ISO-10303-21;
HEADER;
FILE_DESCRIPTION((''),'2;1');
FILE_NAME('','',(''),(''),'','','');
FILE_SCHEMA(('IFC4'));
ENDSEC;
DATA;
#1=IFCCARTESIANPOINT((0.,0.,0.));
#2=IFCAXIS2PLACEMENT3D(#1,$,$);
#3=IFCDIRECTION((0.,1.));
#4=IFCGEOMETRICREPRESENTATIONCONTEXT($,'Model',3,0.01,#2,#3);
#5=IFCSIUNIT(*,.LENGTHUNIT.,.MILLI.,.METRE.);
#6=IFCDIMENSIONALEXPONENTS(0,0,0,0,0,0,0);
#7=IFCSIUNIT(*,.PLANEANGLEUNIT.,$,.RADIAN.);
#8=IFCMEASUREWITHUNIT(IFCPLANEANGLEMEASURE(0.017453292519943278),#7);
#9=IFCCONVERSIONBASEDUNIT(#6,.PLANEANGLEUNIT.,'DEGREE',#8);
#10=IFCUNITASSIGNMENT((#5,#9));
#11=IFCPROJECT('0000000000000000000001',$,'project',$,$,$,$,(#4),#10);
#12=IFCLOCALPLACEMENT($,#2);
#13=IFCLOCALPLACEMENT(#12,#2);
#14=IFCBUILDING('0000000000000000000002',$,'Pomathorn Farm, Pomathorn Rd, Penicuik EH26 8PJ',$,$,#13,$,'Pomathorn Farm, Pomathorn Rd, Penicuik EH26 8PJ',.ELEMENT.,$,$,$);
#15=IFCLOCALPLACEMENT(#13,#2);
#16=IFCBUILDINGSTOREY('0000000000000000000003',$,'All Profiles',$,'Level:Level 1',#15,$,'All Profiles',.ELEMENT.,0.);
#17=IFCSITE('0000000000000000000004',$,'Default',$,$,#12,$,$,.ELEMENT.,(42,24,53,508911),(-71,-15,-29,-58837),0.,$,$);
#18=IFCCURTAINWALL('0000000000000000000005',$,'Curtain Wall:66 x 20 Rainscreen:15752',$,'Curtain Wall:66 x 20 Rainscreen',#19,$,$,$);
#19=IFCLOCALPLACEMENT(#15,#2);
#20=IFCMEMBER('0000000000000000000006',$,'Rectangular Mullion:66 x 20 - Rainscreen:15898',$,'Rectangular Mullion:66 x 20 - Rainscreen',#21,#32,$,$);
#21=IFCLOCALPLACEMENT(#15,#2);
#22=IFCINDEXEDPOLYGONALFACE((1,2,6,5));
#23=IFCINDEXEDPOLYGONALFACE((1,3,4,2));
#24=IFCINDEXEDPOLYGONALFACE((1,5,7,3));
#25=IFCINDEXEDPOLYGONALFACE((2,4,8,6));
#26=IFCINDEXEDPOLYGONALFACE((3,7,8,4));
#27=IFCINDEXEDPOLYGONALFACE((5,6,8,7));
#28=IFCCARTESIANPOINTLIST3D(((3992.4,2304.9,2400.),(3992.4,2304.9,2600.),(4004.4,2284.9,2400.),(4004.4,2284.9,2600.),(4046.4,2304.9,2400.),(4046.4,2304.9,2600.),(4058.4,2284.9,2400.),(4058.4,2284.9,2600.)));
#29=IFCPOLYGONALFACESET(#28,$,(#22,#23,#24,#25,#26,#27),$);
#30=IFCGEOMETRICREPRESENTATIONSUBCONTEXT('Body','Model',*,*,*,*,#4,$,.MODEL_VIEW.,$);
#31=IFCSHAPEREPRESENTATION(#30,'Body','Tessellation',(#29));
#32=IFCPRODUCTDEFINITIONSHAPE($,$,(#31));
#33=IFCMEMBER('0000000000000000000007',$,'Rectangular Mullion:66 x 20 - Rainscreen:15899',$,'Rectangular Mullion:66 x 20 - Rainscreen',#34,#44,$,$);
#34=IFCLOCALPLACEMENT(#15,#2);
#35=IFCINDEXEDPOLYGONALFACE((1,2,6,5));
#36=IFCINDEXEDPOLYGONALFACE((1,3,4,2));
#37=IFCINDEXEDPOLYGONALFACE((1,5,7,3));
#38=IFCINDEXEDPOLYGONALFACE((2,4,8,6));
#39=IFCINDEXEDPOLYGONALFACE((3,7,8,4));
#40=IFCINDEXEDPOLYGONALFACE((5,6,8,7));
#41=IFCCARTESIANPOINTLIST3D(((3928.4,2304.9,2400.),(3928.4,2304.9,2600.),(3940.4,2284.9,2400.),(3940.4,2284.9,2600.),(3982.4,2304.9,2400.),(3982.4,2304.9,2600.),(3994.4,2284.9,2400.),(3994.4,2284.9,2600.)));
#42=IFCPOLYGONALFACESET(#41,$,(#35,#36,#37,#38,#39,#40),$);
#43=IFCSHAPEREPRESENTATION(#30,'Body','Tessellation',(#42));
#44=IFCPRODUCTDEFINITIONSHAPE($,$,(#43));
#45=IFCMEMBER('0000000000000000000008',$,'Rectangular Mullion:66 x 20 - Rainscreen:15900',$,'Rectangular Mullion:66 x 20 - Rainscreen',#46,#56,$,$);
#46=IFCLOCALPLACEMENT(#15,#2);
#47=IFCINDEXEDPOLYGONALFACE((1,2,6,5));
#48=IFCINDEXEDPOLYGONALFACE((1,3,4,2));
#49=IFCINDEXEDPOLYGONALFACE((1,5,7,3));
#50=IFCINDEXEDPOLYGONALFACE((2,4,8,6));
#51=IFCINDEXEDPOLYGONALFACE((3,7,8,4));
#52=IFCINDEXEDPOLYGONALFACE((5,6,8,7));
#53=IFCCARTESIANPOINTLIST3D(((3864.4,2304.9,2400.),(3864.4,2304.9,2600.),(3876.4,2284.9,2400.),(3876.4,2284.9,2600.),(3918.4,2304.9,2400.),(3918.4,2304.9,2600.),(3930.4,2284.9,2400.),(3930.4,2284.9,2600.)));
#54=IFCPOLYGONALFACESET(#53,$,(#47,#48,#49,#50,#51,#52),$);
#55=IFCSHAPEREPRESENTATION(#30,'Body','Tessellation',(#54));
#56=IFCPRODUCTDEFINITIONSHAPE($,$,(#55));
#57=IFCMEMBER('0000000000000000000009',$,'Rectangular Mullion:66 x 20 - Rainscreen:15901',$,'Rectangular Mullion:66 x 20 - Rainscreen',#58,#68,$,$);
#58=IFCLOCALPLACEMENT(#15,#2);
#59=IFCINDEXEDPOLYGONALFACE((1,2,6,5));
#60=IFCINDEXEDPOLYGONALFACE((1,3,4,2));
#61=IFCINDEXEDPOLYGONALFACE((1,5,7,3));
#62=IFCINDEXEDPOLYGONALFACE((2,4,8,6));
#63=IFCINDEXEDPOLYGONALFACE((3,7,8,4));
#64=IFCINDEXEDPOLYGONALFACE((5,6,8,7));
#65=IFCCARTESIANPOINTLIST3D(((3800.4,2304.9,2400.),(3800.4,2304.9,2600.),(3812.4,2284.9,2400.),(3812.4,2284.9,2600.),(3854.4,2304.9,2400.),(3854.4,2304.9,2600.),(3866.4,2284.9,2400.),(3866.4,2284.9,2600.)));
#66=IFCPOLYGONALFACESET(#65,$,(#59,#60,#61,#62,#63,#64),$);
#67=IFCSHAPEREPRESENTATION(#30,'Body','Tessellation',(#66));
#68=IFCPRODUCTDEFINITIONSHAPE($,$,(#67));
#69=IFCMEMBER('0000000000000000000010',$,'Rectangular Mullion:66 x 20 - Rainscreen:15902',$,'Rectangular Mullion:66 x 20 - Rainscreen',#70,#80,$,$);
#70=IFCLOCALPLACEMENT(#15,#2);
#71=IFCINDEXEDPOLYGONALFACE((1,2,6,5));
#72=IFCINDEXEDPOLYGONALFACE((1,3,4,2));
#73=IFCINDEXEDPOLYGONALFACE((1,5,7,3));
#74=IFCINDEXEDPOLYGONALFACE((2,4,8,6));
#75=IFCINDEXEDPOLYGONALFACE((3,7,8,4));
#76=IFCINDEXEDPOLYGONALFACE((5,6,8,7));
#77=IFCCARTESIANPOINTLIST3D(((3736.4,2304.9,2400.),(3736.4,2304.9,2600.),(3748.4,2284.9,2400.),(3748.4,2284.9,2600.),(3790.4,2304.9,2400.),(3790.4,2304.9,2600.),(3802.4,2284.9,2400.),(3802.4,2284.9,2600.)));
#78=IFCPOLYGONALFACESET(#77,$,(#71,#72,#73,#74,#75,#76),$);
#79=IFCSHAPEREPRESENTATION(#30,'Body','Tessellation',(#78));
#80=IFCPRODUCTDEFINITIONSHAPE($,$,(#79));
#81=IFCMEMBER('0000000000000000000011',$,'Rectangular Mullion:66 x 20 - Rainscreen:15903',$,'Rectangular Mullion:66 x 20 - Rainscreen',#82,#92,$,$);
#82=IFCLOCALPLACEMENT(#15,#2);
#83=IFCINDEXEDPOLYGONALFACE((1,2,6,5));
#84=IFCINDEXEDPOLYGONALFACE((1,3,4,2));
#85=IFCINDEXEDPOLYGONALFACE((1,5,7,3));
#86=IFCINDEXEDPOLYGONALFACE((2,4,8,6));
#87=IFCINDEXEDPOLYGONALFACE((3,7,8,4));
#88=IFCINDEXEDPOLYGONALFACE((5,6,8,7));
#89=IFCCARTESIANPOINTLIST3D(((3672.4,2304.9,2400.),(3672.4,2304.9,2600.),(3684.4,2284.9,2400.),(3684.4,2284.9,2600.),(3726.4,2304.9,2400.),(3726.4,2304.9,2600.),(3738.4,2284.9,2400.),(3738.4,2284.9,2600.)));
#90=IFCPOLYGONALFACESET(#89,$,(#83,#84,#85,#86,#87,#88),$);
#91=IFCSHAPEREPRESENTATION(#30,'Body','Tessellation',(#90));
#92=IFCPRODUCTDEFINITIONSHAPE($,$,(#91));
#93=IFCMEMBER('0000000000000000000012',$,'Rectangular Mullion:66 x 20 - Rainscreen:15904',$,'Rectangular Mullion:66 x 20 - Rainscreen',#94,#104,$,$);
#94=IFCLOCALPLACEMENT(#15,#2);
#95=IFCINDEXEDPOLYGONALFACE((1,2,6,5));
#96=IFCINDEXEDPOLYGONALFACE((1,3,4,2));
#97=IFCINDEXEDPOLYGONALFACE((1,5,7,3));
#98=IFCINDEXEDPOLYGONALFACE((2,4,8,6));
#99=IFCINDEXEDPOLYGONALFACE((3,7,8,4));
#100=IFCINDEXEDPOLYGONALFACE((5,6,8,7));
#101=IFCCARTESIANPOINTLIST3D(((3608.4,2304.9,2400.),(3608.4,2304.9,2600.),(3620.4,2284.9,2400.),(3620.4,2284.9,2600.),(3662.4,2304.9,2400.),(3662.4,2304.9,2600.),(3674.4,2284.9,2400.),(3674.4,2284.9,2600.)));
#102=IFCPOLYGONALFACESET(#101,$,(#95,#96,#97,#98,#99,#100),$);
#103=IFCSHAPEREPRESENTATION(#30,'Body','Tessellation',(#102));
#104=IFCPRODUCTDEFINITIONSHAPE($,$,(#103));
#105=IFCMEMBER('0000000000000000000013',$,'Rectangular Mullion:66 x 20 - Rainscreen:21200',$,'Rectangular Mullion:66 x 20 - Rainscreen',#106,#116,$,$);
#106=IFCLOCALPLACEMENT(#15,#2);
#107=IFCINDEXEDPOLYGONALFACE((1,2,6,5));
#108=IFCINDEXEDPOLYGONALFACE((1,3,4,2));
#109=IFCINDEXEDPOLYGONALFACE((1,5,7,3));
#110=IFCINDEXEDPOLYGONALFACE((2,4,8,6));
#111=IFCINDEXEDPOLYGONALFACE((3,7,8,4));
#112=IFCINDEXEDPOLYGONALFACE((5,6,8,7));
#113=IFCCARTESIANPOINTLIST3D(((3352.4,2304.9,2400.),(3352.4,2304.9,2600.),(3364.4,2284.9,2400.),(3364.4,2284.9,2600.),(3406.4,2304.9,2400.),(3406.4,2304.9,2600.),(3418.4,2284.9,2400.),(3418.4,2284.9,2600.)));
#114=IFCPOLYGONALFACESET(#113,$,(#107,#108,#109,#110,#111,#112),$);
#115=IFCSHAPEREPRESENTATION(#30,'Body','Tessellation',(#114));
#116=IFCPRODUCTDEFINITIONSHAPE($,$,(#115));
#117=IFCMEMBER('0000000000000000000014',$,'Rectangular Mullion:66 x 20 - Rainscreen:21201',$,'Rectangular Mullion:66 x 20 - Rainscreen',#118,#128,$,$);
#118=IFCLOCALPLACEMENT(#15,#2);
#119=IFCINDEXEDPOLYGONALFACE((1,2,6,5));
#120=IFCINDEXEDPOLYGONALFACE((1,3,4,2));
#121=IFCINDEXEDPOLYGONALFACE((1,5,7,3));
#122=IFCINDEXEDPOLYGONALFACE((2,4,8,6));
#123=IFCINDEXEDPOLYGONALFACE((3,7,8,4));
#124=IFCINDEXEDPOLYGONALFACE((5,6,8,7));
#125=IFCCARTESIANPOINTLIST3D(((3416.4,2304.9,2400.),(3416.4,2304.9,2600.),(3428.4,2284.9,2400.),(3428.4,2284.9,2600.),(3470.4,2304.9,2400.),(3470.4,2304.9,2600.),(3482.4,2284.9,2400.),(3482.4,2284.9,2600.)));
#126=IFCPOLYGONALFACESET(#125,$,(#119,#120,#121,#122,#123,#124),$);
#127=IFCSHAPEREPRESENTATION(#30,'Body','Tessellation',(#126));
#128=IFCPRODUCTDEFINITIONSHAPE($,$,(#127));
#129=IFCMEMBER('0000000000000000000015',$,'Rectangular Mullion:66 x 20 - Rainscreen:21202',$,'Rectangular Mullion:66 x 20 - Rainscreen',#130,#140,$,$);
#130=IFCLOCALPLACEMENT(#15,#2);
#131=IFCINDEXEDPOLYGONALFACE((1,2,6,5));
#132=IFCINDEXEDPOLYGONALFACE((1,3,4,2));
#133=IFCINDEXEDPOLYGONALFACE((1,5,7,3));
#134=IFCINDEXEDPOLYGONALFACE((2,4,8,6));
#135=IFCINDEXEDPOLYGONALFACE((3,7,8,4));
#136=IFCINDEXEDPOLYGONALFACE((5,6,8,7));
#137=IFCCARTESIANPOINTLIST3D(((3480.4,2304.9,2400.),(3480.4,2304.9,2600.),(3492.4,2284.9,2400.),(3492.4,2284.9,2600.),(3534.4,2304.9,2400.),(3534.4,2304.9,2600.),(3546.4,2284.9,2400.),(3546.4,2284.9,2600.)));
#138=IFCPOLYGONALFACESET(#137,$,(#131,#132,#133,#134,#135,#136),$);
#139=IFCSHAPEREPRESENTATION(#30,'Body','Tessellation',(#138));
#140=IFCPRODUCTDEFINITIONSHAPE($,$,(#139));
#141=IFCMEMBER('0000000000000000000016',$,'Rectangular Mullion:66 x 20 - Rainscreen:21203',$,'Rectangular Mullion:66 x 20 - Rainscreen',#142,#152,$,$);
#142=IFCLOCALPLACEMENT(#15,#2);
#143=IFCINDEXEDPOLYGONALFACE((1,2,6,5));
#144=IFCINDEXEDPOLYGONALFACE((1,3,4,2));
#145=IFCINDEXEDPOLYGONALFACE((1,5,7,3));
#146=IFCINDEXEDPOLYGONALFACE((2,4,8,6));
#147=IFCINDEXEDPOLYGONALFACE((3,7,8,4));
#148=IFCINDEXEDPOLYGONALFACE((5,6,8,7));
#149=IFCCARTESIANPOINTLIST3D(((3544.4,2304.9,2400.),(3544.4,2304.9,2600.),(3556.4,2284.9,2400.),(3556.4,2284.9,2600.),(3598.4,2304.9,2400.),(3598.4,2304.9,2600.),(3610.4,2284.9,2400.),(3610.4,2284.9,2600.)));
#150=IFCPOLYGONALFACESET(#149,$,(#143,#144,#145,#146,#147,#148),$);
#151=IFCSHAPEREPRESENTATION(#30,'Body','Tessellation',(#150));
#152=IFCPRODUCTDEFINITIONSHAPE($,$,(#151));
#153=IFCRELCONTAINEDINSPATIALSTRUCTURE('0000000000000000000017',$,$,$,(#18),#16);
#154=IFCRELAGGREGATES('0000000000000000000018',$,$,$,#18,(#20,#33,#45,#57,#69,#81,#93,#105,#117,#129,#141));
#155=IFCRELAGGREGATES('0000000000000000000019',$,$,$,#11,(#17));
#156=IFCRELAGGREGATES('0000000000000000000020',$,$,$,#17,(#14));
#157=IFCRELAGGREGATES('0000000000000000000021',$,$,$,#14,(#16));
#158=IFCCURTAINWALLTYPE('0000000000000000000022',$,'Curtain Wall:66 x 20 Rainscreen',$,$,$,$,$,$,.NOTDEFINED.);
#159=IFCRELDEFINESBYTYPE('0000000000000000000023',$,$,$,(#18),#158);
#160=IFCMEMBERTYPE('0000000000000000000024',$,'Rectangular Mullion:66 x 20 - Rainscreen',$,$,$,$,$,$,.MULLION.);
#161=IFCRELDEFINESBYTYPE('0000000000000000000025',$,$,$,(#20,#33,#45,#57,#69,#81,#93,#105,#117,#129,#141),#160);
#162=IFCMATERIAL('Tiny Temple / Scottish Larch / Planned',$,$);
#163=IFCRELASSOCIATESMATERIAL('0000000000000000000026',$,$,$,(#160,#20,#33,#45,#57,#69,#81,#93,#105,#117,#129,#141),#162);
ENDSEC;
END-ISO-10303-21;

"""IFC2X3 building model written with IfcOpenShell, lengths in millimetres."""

from ifc_helpers import new_model, entity, si_unit, converted_unit, direction, frame, origin, place, context, subcontext, project, spatial, polyline, outline, extrude, source, transform, mapped, material, type_object, type_shapes, element, aggregate, save


model = new_model("IFC2X3")

# Units and contexts
model_context = context("Model", 3, precision=0.01, world=origin(), true_north=direction((0.0, 1.0)))
body_context = subcontext(model_context, "Body", "Model", "MODEL_VIEW")
ifc_project = project(units=[si_unit("LENGTHUNIT", "METRE", prefix="MILLI"), converted_unit("PLANEANGLEUNIT", "DEGREE", entity("IfcPlaneAngleMeasure", 0.017453292519943278), si_unit("PLANEANGLEUNIT", "RADIAN"), dimensions=[0, 0, 0, 0, 0, 0, 0])], contexts=[model_context])

# Site, building, storey
site_placement = place(None, origin())
site = spatial("IfcSite", under=ifc_project, at=site_placement, Name="Default", CompositionType="ELEMENT", RefLatitude=(42, 24, 53, 508911), RefLongitude=(-71, -15, -29, -58837), RefElevation=0.0)
building_placement = place(site_placement, origin())
building = spatial("IfcBuilding", under=site, at=building_placement, Name="Pomathorn Farm, Pomathorn Rd, Penicuik EH26 8PJ", LongName="Pomathorn Farm, Pomathorn Rd, Penicuik EH26 8PJ", CompositionType="ELEMENT")
storey_placement = place(building_placement, origin())
storey = spatial("IfcBuildingStorey", under=building, at=storey_placement, Name="All Profiles", ObjectType="Level:Level 1", LongName="All Profiles", CompositionType="ELEMENT", Elevation=0.0)

# Curtain wall, members
ifc_material = material(Name="Tiny Temple / Scottish Larch / Planned")
curtain_wall_type_1 = type_object("IfcCurtainWallType", Name="Curtain Wall:66 x 20 Rainscreen", PredefinedType="NOTDEFINED")
curtain_wall_1_placement = place(storey_placement, origin())
curtain_wall_1 = element("IfcCurtainWall", 1, at=curtain_wall_1_placement, inside=storey, type_object=curtain_wall_type_1, Name="Curtain Wall:66 x 20 Rainscreen:15752", ObjectType="Curtain Wall:66 x 20 Rainscreen")
member_type_1 = type_object("IfcMemberType", Name="Rectangular Mullion:66 x 20 - Rainscreen", PredefinedType="MULLION", material=ifc_material)
shared_shape_1 = source(origin(), body_context, "Body", "SweptSolid", [
    extrude(outline(polyline([(2.2, -23.2), (25.6, -23.2), (-2.2, 23.2), (-25.6, 23.2), (2.2, -23.2)])), frame((-33.0, -10.0, -200.0), z_axis=(0.0, 0.0, 1.0), x_axis=(0.514496, 0.857493, 0.0)), (0.0, 0.0, 1.0), 200.0),
])
type_shapes(member_type_1, [shared_shape_1])
member_1_placement = place(curtain_wall_1_placement, frame((4058.4, 2284.9, 2400.0), z_axis=(0.0, 0.0, -1.0), x_axis=(1.0, 0.0, 0.0)))
member_1 = element("IfcMember", 2, at=member_1_placement, type_object=member_type_1, material=ifc_material, Name="Rectangular Mullion:66 x 20 - Rainscreen:15898", ObjectType="Rectangular Mullion:66 x 20 - Rainscreen", context=body_context, shape_type="MappedRepresentation", body=[
    mapped(shared_shape_1, transform((0.0, 0.0, 0.0), scale=1.0)),
])
member_2_placement = place(curtain_wall_1_placement, frame((3994.4, 2284.9, 2400.0), z_axis=(0.0, 0.0, -1.0), x_axis=(1.0, 0.0, 0.0)))
member_2 = element("IfcMember", 3, at=member_2_placement, type_object=member_type_1, material=ifc_material, Name="Rectangular Mullion:66 x 20 - Rainscreen:15899", ObjectType="Rectangular Mullion:66 x 20 - Rainscreen", context=body_context, shape_type="MappedRepresentation", body=[
    mapped(shared_shape_1, transform((0.0, 0.0, 0.0), scale=1.0)),
])
member_3_placement = place(curtain_wall_1_placement, frame((3930.4, 2284.9, 2400.0), z_axis=(0.0, 0.0, -1.0), x_axis=(1.0, 0.0, 0.0)))
member_3 = element("IfcMember", 4, at=member_3_placement, type_object=member_type_1, material=ifc_material, Name="Rectangular Mullion:66 x 20 - Rainscreen:15900", ObjectType="Rectangular Mullion:66 x 20 - Rainscreen", context=body_context, shape_type="MappedRepresentation", body=[
    mapped(shared_shape_1, transform((0.0, 0.0, 0.0), scale=1.0)),
])
member_4_placement = place(curtain_wall_1_placement, frame((3866.4, 2284.9, 2400.0), z_axis=(0.0, 0.0, -1.0), x_axis=(1.0, 0.0, 0.0)))
member_4 = element("IfcMember", 5, at=member_4_placement, type_object=member_type_1, material=ifc_material, Name="Rectangular Mullion:66 x 20 - Rainscreen:15901", ObjectType="Rectangular Mullion:66 x 20 - Rainscreen", context=body_context, shape_type="MappedRepresentation", body=[
    mapped(shared_shape_1, transform((0.0, 0.0, 0.0), scale=1.0)),
])
member_5_placement = place(curtain_wall_1_placement, frame((3802.4, 2284.9, 2400.0), z_axis=(0.0, 0.0, -1.0), x_axis=(1.0, 0.0, 0.0)))
member_5 = element("IfcMember", 6, at=member_5_placement, type_object=member_type_1, material=ifc_material, Name="Rectangular Mullion:66 x 20 - Rainscreen:15902", ObjectType="Rectangular Mullion:66 x 20 - Rainscreen", context=body_context, shape_type="MappedRepresentation", body=[
    mapped(shared_shape_1, transform((0.0, 0.0, 0.0), scale=1.0)),
])
member_6_placement = place(curtain_wall_1_placement, frame((3738.4, 2284.9, 2400.0), z_axis=(0.0, 0.0, -1.0), x_axis=(1.0, 0.0, 0.0)))
member_6 = element("IfcMember", 7, at=member_6_placement, type_object=member_type_1, material=ifc_material, Name="Rectangular Mullion:66 x 20 - Rainscreen:15903", ObjectType="Rectangular Mullion:66 x 20 - Rainscreen", context=body_context, shape_type="MappedRepresentation", body=[
    mapped(shared_shape_1, transform((0.0, 0.0, 0.0), scale=1.0)),
])
member_7_placement = place(curtain_wall_1_placement, frame((3674.4, 2284.9, 2400.0), z_axis=(0.0, 0.0, -1.0), x_axis=(1.0, 0.0, 0.0)))
member_7 = element("IfcMember", 8, at=member_7_placement, type_object=member_type_1, material=ifc_material, Name="Rectangular Mullion:66 x 20 - Rainscreen:15904", ObjectType="Rectangular Mullion:66 x 20 - Rainscreen", context=body_context, shape_type="MappedRepresentation", body=[
    mapped(shared_shape_1, transform((0.0, 0.0, 0.0), scale=1.0)),
])
member_8_placement = place(curtain_wall_1_placement, frame((3418.4, 2284.9, 2400.0), z_axis=(0.0, 0.0, -1.0), x_axis=(1.0, 0.0, 0.0)))
member_8 = element("IfcMember", 9, at=member_8_placement, type_object=member_type_1, material=ifc_material, Name="Rectangular Mullion:66 x 20 - Rainscreen:21200", ObjectType="Rectangular Mullion:66 x 20 - Rainscreen", context=body_context, shape_type="MappedRepresentation", body=[
    mapped(shared_shape_1, transform((0.0, 0.0, 0.0), scale=1.0)),
])
member_9_placement = place(curtain_wall_1_placement, frame((3482.4, 2284.9, 2400.0), z_axis=(0.0, 0.0, -1.0), x_axis=(1.0, 0.0, 0.0)))
member_9 = element("IfcMember", 10, at=member_9_placement, type_object=member_type_1, material=ifc_material, Name="Rectangular Mullion:66 x 20 - Rainscreen:21201", ObjectType="Rectangular Mullion:66 x 20 - Rainscreen", context=body_context, shape_type="MappedRepresentation", body=[
    mapped(shared_shape_1, transform((0.0, 0.0, 0.0), scale=1.0)),
])
member_10_placement = place(curtain_wall_1_placement, frame((3546.4, 2284.9, 2400.0), z_axis=(0.0, 0.0, -1.0), x_axis=(1.0, 0.0, 0.0)))
member_10 = element("IfcMember", 11, at=member_10_placement, type_object=member_type_1, material=ifc_material, Name="Rectangular Mullion:66 x 20 - Rainscreen:21202", ObjectType="Rectangular Mullion:66 x 20 - Rainscreen", context=body_context, shape_type="MappedRepresentation", body=[
    mapped(shared_shape_1, transform((0.0, 0.0, 0.0), scale=1.0)),
])
member_11_placement = place(curtain_wall_1_placement, frame((3610.4, 2284.9, 2400.0), z_axis=(0.0, 0.0, -1.0), x_axis=(1.0, 0.0, 0.0)))
member_11 = element("IfcMember", 12, at=member_11_placement, type_object=member_type_1, material=ifc_material, Name="Rectangular Mullion:66 x 20 - Rainscreen:21203", ObjectType="Rectangular Mullion:66 x 20 - Rainscreen", context=body_context, shape_type="MappedRepresentation", body=[
    mapped(shared_shape_1, transform((0.0, 0.0, 0.0), scale=1.0)),
])
aggregate(curtain_wall_1, [member_1, member_2, member_3, member_4, member_5, member_6, member_7, member_8, member_9, member_10, member_11])

save(model, "model.ifc")
